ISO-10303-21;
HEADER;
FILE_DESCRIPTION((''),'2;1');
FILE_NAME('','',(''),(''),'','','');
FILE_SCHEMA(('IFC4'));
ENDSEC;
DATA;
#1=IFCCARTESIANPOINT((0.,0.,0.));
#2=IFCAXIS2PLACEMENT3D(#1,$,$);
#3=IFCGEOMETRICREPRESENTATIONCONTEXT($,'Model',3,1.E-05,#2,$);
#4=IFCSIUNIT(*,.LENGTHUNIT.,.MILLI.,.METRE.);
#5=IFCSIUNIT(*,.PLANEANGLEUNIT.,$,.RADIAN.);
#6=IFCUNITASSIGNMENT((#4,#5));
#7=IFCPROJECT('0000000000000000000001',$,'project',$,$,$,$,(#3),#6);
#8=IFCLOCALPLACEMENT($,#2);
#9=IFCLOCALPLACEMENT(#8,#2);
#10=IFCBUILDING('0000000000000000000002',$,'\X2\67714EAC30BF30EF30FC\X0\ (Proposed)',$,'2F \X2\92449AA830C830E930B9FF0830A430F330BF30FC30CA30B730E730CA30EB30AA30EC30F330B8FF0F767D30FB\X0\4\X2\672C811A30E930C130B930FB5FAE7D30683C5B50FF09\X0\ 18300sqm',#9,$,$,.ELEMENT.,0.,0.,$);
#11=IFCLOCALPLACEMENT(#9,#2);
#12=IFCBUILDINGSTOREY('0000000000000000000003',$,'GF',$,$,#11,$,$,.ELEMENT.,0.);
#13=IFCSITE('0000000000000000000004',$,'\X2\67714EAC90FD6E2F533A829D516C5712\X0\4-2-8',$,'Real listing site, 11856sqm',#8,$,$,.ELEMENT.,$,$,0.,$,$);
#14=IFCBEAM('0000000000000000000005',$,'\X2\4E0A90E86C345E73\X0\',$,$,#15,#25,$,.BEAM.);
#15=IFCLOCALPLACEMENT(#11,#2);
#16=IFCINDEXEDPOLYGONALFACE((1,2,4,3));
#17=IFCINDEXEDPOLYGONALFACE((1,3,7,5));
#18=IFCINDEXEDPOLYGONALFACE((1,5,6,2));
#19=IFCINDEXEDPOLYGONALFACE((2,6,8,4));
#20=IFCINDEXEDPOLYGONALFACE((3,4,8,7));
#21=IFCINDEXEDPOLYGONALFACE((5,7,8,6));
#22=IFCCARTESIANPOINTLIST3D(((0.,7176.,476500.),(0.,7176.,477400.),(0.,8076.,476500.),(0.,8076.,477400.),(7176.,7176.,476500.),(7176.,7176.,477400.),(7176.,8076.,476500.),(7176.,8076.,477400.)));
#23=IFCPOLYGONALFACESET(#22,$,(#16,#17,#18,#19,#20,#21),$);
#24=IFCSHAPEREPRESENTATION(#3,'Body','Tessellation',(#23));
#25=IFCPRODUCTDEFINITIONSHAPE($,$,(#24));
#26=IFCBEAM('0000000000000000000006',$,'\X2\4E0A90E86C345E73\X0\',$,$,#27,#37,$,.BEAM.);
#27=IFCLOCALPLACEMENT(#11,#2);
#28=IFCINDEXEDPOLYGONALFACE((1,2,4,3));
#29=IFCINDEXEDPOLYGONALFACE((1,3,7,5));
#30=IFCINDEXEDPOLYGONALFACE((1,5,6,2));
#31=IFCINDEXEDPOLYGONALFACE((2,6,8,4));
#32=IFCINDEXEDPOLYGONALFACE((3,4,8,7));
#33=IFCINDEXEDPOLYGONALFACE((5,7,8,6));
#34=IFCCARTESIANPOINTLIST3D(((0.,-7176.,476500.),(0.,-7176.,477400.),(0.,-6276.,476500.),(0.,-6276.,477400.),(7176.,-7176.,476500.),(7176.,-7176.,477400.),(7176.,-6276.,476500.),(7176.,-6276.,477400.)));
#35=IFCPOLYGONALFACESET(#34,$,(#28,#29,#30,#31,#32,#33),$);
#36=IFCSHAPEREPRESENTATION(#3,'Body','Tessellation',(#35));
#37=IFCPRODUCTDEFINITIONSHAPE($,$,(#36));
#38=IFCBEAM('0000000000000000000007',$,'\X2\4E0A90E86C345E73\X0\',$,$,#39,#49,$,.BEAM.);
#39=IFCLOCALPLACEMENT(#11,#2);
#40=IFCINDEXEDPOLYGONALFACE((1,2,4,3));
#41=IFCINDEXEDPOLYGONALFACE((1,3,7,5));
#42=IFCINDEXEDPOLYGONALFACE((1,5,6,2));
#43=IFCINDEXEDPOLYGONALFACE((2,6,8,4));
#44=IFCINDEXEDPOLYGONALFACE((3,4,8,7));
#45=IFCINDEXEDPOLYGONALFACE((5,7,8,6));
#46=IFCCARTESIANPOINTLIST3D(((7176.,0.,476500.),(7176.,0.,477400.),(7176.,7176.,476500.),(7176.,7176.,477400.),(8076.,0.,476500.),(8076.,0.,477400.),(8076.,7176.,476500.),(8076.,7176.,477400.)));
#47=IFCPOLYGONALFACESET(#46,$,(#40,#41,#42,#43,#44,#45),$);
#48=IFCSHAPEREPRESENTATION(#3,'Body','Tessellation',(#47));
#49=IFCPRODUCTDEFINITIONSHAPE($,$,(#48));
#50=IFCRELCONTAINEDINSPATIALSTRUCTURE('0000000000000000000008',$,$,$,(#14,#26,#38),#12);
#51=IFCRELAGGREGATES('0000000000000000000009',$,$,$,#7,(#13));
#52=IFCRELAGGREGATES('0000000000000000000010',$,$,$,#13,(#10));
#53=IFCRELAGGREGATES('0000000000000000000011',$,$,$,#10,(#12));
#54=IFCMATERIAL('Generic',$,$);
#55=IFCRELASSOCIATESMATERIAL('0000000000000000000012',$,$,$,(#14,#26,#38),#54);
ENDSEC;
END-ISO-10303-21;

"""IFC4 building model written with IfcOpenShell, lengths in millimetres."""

from ifc_helpers import new_model, si_unit, frame, frame_2d, origin, place, context, project, spatial, rectangle, extrude, material, element, save


model = new_model("IFC4")

# Units and contexts
model_context = context("Model", 3, precision=1e-05, world=origin())
ifc_project = project(units=[si_unit("LENGTHUNIT", "METRE", prefix="MILLI"), si_unit("PLANEANGLEUNIT", "RADIAN")], contexts=[model_context])

# Site, building, storey
site_placement = place(None, origin())
site = spatial("IfcSite", under=ifc_project, at=site_placement, Name="東京都港区芝公園4-2-8", ObjectType="Real listing site, 11856sqm", CompositionType="ELEMENT", RefElevation=0.0)
building_placement = place(site_placement, origin())
building = spatial("IfcBuilding", under=site, at=building_placement, Name="東京タワー (Proposed)", ObjectType="2F 鉄骨トラス（インターナショナルオレンジ／白・4本脚ラチス・微細格子） 18300sqm", CompositionType="ELEMENT", ElevationOfRefHeight=0.0, ElevationOfTerrain=0.0)
storey_placement = place(building_placement, origin())
storey = spatial("IfcBuildingStorey", under=building, at=storey_placement, Name="GF", CompositionType="ELEMENT", Elevation=0.0)

# Shared definitions
ifc_material = material(Name="Generic")

# Beams
beam_1_placement = place(storey_placement, frame((0.0, 3588.0, 238250.0)))
element("IfcBeam", 1, at=beam_1_placement, inside=storey, material=ifc_material, Name="上部水平", PredefinedType="BEAM", context=model_context, shape_type="SweptSolid", body=[
    extrude(rectangle(XDim=7176.0, YDim=900.0, at=frame_2d((3588.0, 450.0))), frame((0.0, 3588.0, 238250.0)), (0.0, 0.0, 1.0), 900.0),
])
beam_2_placement = place(storey_placement, frame((0.0, -3588.0, 238250.0)))
element("IfcBeam", 2, at=beam_2_placement, inside=storey, material=ifc_material, Name="上部水平", PredefinedType="BEAM", context=model_context, shape_type="SweptSolid", body=[
    extrude(rectangle(XDim=7176.0, YDim=900.0, at=frame_2d((3588.0, 450.0))), frame((0.0, -3588.0, 238250.0)), (0.0, 0.0, 1.0), 900.0),
])
beam_3_placement = place(storey_placement, frame((3588.0, 0.0, 238250.0)))
element("IfcBeam", 3, at=beam_3_placement, inside=storey, material=ifc_material, Name="上部水平", PredefinedType="BEAM", context=model_context, shape_type="SweptSolid", body=[
    extrude(rectangle(XDim=900.0, YDim=7176.0, at=frame_2d((450.0, 3588.0))), frame((3588.0, 0.0, 238250.0)), (0.0, 0.0, 1.0), 900.0),
])

save(model, "model.ifc")
